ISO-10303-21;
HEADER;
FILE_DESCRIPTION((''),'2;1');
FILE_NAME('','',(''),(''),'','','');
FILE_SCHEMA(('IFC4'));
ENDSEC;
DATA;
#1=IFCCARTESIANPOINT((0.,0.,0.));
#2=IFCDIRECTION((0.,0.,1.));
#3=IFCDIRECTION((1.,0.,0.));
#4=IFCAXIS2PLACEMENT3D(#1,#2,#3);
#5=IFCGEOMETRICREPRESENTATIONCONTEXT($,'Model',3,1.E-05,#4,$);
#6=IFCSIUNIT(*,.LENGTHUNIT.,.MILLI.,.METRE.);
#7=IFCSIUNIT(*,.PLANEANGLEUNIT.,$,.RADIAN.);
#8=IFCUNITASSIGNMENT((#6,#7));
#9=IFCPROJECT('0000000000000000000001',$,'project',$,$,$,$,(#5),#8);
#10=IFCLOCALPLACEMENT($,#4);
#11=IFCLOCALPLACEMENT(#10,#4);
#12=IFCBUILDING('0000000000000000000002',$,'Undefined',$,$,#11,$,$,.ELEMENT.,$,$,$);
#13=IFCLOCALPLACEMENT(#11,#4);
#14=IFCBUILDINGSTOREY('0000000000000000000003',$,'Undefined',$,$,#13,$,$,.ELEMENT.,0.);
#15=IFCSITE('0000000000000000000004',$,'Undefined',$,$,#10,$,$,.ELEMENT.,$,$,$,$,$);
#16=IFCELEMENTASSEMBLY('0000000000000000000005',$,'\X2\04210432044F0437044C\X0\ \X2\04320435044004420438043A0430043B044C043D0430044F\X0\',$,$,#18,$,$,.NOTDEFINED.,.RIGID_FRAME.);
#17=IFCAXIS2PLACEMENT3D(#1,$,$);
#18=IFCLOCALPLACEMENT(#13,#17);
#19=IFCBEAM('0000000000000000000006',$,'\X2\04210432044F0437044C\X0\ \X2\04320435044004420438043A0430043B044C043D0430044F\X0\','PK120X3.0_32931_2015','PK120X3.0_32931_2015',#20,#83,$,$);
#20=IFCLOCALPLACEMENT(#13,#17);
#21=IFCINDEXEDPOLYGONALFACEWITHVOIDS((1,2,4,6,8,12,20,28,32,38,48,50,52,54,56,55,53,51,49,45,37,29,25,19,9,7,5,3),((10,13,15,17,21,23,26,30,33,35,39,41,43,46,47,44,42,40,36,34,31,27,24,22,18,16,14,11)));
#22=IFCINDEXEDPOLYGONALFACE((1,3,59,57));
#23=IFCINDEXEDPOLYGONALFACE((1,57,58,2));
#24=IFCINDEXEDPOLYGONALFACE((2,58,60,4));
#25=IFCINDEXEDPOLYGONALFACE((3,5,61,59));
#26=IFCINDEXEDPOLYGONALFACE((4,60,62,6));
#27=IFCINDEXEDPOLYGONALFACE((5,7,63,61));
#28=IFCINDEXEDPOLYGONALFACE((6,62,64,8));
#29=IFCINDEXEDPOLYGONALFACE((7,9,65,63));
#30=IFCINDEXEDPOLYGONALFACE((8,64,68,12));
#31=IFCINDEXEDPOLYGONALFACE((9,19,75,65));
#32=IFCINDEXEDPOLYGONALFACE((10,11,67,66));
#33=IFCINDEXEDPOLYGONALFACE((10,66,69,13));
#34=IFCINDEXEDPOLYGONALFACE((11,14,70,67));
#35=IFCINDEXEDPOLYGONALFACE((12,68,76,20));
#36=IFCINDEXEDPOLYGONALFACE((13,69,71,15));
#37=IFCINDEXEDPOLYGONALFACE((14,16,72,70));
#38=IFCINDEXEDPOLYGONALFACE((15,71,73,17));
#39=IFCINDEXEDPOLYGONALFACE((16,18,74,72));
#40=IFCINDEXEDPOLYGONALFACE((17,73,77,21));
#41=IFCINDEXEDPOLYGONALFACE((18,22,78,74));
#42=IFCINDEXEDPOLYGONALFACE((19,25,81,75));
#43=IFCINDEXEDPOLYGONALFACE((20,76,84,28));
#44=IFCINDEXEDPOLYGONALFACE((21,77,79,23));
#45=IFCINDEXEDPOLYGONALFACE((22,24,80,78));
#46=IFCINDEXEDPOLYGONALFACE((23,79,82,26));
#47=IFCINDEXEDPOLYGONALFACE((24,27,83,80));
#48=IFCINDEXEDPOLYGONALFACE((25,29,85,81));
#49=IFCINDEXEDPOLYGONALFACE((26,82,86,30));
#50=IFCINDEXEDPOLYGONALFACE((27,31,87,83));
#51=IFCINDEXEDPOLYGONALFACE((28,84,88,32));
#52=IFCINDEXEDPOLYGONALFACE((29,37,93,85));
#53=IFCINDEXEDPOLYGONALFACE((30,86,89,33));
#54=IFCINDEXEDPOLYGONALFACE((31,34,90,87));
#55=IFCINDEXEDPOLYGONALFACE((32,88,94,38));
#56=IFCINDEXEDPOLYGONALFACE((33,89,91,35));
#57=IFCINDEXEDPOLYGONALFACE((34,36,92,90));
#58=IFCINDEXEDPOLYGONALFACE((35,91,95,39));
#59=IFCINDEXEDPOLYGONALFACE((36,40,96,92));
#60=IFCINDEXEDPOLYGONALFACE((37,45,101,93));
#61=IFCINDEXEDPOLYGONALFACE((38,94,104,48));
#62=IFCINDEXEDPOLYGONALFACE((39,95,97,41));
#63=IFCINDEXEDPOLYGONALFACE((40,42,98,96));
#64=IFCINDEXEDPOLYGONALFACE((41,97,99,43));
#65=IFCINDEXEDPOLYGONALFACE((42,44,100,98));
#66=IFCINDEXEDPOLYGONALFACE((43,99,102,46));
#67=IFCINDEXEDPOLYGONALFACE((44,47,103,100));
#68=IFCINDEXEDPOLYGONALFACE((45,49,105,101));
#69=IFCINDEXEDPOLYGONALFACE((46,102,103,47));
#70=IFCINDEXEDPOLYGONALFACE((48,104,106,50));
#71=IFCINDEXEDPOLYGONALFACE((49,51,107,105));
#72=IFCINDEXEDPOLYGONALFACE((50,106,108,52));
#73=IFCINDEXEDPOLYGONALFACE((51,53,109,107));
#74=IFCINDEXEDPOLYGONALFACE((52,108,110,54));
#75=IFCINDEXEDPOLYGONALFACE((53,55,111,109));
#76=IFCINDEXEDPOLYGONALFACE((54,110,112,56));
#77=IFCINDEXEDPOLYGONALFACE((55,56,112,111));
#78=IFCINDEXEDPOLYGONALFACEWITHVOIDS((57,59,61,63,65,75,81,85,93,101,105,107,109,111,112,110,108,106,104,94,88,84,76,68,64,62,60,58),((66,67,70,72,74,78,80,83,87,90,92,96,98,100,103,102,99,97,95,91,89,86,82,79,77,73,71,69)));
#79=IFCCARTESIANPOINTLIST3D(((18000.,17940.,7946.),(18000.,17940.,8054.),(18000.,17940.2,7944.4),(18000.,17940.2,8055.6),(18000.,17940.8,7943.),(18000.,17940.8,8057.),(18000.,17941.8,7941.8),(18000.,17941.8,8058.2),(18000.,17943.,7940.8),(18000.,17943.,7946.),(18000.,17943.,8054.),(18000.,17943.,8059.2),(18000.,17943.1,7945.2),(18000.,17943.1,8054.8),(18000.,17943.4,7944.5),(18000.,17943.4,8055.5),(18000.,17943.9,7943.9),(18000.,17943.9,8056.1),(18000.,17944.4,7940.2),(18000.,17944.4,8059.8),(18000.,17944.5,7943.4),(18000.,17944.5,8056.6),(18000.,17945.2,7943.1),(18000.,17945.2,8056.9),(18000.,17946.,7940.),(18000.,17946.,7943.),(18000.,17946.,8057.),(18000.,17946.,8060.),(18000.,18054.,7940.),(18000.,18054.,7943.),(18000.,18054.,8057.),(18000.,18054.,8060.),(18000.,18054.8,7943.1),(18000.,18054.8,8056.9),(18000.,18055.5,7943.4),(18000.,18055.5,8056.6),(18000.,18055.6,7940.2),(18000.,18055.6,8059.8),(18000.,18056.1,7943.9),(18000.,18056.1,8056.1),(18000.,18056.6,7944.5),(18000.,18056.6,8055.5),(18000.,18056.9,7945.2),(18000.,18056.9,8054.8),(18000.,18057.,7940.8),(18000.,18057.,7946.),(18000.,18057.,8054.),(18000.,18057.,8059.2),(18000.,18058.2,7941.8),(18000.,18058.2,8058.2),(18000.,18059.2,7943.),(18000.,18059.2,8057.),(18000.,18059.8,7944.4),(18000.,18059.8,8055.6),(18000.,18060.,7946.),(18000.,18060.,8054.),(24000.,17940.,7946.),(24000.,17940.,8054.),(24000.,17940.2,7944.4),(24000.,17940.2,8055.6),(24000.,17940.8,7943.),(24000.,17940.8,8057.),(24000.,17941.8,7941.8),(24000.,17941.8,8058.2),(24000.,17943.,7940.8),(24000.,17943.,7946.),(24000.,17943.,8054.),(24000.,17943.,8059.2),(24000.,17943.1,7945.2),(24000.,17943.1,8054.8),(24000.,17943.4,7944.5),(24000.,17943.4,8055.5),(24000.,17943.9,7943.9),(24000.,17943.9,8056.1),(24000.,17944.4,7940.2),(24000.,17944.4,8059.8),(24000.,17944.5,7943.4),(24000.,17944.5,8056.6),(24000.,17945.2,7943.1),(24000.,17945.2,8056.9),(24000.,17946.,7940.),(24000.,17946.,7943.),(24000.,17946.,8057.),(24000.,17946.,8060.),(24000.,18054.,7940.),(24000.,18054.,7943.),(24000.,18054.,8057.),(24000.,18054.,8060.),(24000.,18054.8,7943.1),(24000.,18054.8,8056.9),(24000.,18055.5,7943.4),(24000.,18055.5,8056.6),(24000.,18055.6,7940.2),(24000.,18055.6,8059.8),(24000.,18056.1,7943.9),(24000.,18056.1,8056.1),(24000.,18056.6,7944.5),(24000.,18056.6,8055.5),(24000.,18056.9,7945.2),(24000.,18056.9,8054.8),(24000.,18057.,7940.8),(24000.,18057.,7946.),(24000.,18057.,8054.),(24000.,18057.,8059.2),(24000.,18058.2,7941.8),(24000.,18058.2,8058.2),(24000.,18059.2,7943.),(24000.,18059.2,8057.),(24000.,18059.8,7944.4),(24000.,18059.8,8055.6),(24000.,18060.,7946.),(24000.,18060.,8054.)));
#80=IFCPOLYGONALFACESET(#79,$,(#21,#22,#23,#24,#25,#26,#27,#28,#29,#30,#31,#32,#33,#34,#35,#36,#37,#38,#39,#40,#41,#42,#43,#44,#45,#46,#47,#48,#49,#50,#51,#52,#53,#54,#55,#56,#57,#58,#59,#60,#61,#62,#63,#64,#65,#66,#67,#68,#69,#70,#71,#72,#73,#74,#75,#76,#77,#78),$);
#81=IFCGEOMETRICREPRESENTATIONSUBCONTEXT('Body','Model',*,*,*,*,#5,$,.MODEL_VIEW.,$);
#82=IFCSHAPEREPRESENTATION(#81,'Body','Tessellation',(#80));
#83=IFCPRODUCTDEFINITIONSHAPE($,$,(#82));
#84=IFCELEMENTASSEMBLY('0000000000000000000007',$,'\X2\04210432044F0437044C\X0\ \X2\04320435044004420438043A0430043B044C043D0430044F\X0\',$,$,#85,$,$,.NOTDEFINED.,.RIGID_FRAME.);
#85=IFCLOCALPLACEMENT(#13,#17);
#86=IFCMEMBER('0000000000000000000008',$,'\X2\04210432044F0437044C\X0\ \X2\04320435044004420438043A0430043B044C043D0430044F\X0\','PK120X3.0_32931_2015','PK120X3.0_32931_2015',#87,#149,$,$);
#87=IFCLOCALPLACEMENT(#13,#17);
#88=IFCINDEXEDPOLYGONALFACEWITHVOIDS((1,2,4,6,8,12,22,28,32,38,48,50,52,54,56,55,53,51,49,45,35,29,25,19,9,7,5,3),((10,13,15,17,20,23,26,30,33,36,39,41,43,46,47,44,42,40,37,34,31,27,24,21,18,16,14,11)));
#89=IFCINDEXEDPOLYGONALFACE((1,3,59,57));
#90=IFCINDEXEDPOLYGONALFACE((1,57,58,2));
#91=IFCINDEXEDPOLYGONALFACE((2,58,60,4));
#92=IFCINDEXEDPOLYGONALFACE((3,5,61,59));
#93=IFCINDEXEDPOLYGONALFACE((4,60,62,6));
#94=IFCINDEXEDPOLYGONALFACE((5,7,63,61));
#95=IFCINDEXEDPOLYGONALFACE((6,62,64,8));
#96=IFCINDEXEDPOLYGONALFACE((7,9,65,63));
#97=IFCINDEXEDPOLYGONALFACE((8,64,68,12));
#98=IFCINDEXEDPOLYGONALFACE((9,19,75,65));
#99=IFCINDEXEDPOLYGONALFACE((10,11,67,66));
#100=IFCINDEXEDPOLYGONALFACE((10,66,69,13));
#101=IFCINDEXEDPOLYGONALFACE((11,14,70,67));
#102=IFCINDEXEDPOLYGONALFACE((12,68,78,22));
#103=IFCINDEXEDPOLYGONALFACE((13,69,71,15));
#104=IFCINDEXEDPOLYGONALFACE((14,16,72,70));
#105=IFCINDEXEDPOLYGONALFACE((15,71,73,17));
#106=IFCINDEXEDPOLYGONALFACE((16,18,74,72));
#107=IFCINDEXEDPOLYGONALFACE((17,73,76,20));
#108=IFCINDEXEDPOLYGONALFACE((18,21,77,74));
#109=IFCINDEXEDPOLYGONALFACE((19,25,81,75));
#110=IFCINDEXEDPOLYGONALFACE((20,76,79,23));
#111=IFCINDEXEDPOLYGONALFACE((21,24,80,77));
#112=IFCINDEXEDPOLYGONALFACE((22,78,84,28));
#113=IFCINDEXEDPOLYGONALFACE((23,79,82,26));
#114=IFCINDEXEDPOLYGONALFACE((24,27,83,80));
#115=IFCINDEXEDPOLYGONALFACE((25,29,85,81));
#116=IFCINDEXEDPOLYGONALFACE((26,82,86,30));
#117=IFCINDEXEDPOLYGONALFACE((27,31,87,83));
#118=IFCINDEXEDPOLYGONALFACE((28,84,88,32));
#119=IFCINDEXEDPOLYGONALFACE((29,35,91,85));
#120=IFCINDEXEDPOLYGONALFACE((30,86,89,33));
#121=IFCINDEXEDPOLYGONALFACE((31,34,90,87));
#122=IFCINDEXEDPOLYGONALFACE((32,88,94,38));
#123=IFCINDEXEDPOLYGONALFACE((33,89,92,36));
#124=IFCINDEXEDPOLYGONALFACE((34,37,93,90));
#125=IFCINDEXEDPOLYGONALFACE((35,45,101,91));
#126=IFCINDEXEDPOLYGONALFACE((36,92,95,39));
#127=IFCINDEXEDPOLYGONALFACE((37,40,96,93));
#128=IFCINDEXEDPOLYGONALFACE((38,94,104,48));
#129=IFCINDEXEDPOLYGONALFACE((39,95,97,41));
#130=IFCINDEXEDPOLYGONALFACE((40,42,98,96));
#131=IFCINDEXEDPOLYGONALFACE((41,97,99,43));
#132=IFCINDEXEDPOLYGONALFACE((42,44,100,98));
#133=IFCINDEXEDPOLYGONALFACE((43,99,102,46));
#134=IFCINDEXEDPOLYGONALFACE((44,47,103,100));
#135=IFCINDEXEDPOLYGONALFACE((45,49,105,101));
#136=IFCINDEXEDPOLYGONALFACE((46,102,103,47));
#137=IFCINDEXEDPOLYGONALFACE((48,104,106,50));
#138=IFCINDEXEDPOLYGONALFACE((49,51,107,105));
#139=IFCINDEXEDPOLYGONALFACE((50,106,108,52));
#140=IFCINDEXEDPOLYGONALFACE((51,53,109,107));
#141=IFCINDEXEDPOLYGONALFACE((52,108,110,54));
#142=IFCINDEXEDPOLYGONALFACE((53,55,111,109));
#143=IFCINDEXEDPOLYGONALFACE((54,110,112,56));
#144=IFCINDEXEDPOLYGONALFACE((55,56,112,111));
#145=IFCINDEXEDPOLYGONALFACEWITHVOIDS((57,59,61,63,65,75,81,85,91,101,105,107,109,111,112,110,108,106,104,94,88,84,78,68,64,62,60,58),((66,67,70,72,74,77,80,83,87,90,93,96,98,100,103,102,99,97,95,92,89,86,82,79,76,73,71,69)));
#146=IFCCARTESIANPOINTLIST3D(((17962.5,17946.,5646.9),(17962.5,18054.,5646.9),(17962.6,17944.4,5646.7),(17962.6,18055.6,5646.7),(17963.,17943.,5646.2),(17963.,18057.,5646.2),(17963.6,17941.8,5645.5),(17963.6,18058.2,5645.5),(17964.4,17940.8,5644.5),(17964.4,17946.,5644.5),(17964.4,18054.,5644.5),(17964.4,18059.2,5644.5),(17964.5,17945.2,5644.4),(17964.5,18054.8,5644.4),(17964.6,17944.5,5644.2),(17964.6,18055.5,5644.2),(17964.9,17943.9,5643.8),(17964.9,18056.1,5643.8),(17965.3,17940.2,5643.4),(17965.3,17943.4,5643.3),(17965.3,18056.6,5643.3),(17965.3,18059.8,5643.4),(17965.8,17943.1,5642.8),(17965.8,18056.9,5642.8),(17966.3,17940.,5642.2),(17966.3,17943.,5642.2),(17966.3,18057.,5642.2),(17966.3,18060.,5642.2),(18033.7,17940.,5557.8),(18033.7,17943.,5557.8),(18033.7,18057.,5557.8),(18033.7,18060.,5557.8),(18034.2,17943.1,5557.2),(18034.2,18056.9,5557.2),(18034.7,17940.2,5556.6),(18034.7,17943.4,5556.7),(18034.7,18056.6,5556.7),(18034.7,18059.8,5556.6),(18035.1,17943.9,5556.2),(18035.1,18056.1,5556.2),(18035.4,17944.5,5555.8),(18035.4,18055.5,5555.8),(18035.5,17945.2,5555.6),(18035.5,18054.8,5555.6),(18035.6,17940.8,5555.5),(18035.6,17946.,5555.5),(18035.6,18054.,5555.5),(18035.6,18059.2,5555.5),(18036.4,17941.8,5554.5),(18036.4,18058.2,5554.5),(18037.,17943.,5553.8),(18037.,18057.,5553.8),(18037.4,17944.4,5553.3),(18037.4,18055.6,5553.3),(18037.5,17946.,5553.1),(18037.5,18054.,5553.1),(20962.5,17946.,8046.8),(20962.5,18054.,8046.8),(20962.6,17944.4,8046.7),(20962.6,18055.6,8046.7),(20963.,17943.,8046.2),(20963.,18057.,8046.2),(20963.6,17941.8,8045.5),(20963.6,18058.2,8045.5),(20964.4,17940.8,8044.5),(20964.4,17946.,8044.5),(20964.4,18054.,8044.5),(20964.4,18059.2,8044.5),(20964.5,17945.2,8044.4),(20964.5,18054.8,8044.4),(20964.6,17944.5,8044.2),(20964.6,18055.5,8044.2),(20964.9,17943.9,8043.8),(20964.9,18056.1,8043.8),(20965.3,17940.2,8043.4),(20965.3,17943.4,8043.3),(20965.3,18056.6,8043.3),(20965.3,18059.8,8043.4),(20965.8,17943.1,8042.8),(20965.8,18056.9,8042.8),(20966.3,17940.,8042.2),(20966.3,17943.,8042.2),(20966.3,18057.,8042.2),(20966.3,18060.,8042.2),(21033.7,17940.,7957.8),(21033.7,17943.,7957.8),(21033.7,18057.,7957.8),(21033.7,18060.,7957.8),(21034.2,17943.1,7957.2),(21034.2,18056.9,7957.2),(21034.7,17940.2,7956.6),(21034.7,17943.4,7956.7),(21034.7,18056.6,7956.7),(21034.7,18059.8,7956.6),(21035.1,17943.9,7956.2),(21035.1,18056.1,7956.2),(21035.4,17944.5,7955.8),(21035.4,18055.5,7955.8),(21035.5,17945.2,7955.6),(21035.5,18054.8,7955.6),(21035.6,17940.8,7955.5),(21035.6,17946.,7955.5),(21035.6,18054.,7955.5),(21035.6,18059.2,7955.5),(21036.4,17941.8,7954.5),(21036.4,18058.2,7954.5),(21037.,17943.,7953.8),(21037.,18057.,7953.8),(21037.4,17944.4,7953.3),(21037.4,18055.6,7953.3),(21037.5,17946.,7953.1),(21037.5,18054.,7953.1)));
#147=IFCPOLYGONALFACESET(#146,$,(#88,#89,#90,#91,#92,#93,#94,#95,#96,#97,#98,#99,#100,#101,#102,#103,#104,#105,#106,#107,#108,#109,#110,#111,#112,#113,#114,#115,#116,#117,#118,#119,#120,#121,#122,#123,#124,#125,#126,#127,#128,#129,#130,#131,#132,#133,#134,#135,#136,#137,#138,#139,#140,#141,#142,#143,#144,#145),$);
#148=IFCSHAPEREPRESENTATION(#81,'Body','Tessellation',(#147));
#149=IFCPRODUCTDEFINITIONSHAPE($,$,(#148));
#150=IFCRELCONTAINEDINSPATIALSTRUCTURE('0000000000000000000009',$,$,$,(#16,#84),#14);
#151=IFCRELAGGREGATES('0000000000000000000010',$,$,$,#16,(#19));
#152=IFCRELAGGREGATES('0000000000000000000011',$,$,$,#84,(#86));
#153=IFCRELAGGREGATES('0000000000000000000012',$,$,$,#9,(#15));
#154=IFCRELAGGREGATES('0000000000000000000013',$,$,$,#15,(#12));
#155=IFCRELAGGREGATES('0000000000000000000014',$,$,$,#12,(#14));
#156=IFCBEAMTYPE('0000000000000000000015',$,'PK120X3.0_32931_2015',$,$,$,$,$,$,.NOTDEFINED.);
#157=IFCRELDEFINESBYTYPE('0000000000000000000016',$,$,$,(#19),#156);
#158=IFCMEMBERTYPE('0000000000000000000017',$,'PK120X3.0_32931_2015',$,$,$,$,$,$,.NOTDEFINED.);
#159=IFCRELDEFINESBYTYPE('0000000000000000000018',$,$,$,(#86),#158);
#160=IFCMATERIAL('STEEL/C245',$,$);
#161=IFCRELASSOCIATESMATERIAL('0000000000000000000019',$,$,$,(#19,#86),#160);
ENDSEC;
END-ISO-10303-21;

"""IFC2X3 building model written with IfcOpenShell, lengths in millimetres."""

from ifc_helpers import new_model, si_unit, frame, origin_with_axes, origin_2d_with_axis, place, context, subcontext, project, spatial, hollow_rectangle, extrude, material, type_object, element, aggregate, save


model = new_model("IFC2X3")

# Units and contexts
model_context = context("Model", 3, precision=1e-05, world=origin_with_axes())
body_context = subcontext(model_context, "Body", "Model", "MODEL_VIEW")
ifc_project = project(units=[si_unit("LENGTHUNIT", "METRE", prefix="MILLI"), si_unit("PLANEANGLEUNIT", "RADIAN")], contexts=[model_context])

# Site, building, storey
site_placement = place(None, origin_with_axes())
site = spatial("IfcSite", under=ifc_project, at=site_placement, Name="Undefined", CompositionType="ELEMENT")
building_placement = place(site_placement, origin_with_axes())
building = spatial("IfcBuilding", under=site, at=building_placement, Name="Undefined", CompositionType="ELEMENT")
storey_placement = place(building_placement, origin_with_axes())
storey = spatial("IfcBuildingStorey", under=building, at=storey_placement, Name="Undefined", CompositionType="ELEMENT", Elevation=0.0)

# Shared definitions
ifc_material_1 = material(Name="STEEL/C245")

# Element assembly, beam
beam_type_1 = type_object("IfcBeamType", Name="PK120X3.0_32931_2015", PredefinedType="NOTDEFINED")
assembly_1_placement = place(storey_placement, origin_with_axes())
assembly_1 = element("IfcElementAssembly", 1, at=assembly_1_placement, inside=storey, Name="Связь вертикальная", AssemblyPlace="NOTDEFINED", PredefinedType="RIGID_FRAME")
beam_1_placement = place(assembly_1_placement, frame((18000.0, 18000.0, 8000.0), z_axis=(0.0, 0.0, 1.0), x_axis=(1.0, 0.0, 0.0)))
beam_1 = element("IfcBeam", 2, at=beam_1_placement, type_object=beam_type_1, material=ifc_material_1, Name="Связь вертикальная", Description="PK120X3.0_32931_2015", ObjectType="PK120X3.0_32931_2015", context=body_context, shape_type="SweptSolid", body=[
    extrude(hollow_rectangle(XDim=120.0, YDim=120.0, WallThickness=3.0, InnerFilletRadius=3.0, OuterFilletRadius=6.0, at=origin_2d_with_axis()), frame((6000.0, 0.0, 0.0), z_axis=(-1.0, 0.0, 0.0), x_axis=(0.0, -1.0, 0.0)), (0.0, 0.0, 1.0), 6000.0),
])
aggregate(assembly_1, [beam_1])

# Element assembly, member
assembly_2_placement = place(storey_placement, origin_with_axes())
assembly_2 = element("IfcElementAssembly", 3, at=assembly_2_placement, inside=storey, Name="Связь вертикальная", AssemblyPlace="NOTDEFINED", PredefinedType="RIGID_FRAME")
member_type_1 = type_object("IfcMemberType", Name="PK120X3.0_32931_2015", PredefinedType="NOTDEFINED")
member_1_placement = place(assembly_2_placement, frame((21000.0, 18000.0, 8000.0), z_axis=(0.624695, 0.0, -0.780869), x_axis=(-0.780869, 0.0, -0.624695)))
member_1 = element("IfcMember", 4, at=member_1_placement, type_object=member_type_1, material=ifc_material_1, Name="Связь вертикальная", Description="PK120X3.0_32931_2015", ObjectType="PK120X3.0_32931_2015", context=body_context, shape_type="SweptSolid", body=[
    extrude(hollow_rectangle(XDim=120.0, YDim=120.0, WallThickness=3.0, InnerFilletRadius=3.0, OuterFilletRadius=6.0, at=origin_2d_with_axis()), frame((3841.9, 0.0, 0.0), z_axis=(-1.0, 0.0, 0.0), x_axis=(0.0, -1.0, 0.0)), (0.0, 0.0, 1.0), 3841.9),
])
aggregate(assembly_2, [member_1])

save(model, "model.ifc")
